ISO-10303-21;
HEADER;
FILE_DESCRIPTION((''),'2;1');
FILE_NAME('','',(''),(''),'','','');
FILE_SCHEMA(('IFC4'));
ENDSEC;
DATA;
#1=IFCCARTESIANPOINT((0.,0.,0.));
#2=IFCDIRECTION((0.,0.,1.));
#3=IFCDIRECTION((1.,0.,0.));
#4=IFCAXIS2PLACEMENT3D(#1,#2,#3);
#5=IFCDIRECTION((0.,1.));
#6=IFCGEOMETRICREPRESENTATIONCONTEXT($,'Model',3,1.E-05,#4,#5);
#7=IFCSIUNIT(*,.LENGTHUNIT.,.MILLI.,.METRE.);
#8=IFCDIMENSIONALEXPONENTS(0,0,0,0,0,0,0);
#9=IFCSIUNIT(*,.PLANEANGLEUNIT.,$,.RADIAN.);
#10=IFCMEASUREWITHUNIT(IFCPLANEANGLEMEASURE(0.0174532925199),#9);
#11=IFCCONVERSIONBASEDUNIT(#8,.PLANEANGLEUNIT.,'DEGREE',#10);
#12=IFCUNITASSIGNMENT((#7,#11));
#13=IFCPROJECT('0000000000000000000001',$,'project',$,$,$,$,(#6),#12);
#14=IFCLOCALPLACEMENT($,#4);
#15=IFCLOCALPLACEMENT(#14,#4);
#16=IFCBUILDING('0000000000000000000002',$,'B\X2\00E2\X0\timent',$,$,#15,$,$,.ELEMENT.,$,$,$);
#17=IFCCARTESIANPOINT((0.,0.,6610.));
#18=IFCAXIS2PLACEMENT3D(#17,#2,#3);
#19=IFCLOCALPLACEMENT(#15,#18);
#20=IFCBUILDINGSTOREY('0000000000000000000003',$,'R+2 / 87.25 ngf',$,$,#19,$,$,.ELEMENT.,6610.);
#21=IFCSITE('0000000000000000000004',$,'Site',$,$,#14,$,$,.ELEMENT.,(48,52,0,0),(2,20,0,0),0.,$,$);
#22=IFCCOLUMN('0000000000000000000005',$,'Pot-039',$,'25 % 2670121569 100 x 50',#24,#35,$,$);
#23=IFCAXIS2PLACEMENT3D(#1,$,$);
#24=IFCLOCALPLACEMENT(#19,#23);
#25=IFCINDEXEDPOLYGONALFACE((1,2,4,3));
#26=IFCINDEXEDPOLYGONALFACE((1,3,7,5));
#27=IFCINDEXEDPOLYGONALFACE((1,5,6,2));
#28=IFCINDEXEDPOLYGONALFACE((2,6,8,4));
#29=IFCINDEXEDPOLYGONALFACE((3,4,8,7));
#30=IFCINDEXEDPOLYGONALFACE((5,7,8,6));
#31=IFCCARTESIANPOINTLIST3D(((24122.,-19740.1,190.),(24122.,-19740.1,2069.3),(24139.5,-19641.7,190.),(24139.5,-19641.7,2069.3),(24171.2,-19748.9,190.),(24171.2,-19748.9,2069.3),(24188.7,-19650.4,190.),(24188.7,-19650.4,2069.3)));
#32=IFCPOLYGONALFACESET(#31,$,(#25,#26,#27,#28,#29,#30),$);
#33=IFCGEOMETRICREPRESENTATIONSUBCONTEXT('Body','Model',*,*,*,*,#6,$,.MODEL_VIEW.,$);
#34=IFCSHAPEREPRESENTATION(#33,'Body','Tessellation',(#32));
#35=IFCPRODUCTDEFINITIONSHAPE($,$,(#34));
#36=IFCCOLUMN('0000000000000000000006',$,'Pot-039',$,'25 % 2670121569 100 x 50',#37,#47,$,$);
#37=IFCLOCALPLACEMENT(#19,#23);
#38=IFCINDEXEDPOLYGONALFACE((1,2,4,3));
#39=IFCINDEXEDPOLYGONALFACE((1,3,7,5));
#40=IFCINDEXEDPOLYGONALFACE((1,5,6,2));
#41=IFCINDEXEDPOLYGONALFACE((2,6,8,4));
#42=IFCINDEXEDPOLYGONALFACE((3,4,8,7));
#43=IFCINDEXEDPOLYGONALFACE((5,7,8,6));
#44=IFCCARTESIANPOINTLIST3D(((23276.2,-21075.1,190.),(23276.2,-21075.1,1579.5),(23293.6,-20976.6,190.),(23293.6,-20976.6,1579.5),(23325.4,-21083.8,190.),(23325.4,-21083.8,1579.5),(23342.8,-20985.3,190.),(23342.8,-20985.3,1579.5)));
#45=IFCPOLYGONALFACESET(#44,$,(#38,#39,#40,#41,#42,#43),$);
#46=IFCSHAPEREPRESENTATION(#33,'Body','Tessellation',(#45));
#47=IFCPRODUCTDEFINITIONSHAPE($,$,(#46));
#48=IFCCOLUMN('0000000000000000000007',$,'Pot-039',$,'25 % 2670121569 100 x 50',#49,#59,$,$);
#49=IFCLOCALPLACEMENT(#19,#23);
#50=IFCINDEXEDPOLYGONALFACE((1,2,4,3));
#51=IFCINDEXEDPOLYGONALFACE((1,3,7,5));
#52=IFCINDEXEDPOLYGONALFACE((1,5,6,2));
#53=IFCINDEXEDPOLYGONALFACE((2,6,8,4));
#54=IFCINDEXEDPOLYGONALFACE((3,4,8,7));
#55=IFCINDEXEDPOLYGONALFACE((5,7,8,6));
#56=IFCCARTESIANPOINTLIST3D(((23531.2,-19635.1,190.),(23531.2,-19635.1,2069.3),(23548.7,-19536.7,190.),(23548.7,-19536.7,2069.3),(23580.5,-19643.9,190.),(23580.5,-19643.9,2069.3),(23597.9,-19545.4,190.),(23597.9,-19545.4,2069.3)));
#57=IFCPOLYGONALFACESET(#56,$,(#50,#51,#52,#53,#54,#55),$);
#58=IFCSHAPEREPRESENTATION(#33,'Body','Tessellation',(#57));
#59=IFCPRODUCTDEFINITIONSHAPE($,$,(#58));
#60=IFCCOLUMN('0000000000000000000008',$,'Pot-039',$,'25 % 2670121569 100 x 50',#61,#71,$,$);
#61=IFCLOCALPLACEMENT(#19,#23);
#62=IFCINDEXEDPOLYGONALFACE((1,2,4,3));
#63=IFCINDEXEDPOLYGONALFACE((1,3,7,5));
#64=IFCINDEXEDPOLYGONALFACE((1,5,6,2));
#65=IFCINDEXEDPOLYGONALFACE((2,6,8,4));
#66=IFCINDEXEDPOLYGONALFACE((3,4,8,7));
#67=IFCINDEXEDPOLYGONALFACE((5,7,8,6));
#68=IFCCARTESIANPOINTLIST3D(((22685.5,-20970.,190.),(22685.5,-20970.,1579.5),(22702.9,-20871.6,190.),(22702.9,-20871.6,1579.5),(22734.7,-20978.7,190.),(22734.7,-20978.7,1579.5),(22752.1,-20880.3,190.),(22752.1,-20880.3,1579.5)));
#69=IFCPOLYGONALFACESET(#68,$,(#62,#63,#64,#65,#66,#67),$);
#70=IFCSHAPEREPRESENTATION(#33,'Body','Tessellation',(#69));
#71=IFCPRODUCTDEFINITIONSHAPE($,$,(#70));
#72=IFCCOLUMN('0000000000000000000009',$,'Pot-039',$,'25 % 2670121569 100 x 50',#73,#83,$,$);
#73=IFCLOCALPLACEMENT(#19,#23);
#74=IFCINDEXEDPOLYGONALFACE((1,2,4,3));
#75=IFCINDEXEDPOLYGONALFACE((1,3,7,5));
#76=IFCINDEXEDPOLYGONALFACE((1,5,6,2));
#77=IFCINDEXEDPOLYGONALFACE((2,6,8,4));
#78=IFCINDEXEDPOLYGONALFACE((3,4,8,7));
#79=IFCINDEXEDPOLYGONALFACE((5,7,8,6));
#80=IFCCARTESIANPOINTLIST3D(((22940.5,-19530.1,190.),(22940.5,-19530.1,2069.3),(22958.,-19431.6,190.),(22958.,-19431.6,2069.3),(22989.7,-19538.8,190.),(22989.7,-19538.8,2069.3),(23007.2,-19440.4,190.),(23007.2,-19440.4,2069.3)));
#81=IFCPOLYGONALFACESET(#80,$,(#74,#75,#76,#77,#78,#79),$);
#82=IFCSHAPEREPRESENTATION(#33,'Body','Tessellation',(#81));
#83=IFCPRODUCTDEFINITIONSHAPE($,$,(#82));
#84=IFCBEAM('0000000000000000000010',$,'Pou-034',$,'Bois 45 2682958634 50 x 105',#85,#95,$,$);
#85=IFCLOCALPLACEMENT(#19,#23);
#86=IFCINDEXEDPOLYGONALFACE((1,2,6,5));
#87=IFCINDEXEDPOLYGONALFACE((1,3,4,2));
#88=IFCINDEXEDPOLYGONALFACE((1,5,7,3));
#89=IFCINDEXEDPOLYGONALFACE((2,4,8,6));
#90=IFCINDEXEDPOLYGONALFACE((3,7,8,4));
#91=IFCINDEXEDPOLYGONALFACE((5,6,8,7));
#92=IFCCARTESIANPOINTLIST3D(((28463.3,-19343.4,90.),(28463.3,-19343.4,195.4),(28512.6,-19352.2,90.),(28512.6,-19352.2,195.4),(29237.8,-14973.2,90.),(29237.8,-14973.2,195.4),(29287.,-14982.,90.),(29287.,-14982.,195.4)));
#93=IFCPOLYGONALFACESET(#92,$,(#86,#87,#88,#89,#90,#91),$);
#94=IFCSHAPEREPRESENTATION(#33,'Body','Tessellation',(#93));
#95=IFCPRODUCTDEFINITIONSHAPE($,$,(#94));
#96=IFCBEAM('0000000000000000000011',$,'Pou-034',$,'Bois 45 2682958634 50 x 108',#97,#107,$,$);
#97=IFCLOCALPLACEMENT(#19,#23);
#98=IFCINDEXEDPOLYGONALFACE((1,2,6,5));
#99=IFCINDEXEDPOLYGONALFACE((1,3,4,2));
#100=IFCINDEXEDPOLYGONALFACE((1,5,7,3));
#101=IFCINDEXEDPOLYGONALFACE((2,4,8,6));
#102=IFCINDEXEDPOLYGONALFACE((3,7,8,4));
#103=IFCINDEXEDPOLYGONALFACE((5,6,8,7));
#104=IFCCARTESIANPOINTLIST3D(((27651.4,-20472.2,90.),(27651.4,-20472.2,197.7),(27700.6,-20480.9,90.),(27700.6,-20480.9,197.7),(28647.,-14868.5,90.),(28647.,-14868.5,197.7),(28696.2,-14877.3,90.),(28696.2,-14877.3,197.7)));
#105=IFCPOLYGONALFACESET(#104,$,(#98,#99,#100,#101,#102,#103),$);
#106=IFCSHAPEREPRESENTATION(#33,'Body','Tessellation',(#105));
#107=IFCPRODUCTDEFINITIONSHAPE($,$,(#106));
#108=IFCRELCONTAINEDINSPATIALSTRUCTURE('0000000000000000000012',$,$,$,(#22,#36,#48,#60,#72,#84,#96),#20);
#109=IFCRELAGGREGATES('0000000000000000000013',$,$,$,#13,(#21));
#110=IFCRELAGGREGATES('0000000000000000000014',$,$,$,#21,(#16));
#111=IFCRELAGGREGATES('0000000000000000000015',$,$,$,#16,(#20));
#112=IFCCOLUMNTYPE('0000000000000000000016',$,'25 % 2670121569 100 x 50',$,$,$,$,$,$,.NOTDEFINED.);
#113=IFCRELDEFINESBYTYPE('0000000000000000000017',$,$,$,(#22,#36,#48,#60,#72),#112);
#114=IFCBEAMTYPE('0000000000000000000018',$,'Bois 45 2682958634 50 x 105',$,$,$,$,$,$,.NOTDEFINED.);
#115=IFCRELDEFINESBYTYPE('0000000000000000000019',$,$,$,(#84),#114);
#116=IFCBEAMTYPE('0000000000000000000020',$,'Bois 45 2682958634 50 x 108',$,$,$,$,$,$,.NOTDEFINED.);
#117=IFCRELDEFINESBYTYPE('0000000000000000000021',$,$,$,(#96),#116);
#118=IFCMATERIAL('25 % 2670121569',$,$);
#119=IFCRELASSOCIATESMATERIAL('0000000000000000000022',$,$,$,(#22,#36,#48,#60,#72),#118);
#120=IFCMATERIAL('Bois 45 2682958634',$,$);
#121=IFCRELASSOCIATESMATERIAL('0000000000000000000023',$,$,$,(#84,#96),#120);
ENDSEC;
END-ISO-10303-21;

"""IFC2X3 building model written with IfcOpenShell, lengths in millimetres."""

from ifc_helpers import new_model, entity, si_unit, converted_unit, direction, frame, frame_2d, origin_with_axes, origin_2d_with_axis, place, context, subcontext, project, spatial, rectangle, extrude, material, type_object, element, save


model = new_model("IFC2X3")

# Units and contexts
model_context = context("Model", 3, precision=1e-05, world=origin_with_axes(), true_north=direction((0.0, 1.0)))
body_context = subcontext(model_context, "Body", "Model", "MODEL_VIEW")
ifc_project = project(units=[si_unit("LENGTHUNIT", "METRE", prefix="MILLI"), converted_unit("PLANEANGLEUNIT", "DEGREE", entity("IfcPlaneAngleMeasure", 0.0174532925199), si_unit("PLANEANGLEUNIT", "RADIAN"), dimensions=[0, 0, 0, 0, 0, 0, 0])], contexts=[model_context])

# Site, building, storey
site_placement = place(None, origin_with_axes())
site = spatial("IfcSite", under=ifc_project, at=site_placement, Name="Site", CompositionType="ELEMENT", RefLatitude=(48, 52, 0, 0), RefLongitude=(2, 20, 0, 0), RefElevation=0.0)
building_placement = place(site_placement, origin_with_axes())
building = spatial("IfcBuilding", under=site, at=building_placement, Name="Bâtiment", CompositionType="ELEMENT")
storey_placement = place(building_placement, frame((0.0, 0.0, 6610.0), z_axis=(0.0, 0.0, 1.0), x_axis=(1.0, 0.0, 0.0)))
storey = spatial("IfcBuildingStorey", under=building, at=storey_placement, Name="R+2 / 87.25 ngf", CompositionType="ELEMENT", Elevation=6610.0)

# Columns
ifc_material_1 = material(Name="25 % 2670121569")
column_type = type_object("IfcColumnType", Name="25 % 2670121569 100 x 50", PredefinedType="NOTDEFINED")
column_1_placement = place(storey_placement, frame((24155.3, -19695.3, 190.0), z_axis=(0.0, 0.0, 1.0), x_axis=(0.17478, 0.984607, 0.0)))
element("IfcColumn", 1, at=column_1_placement, inside=storey, type_object=column_type, material=ifc_material_1, Name="Pot-039", ObjectType="25 % 2670121569 100 x 50", context=body_context, shape_type="SweptSolid", body=[
    extrude(rectangle(XDim=100.0, YDim=50.0, at=origin_2d_with_axis()), origin_with_axes(), (0.0, 0.0, 1.0), 1879.3),
])
column_2_placement = place(storey_placement, frame((23309.5, -21030.2, 190.0), z_axis=(0.0, 0.0, 1.0), x_axis=(0.17408, 0.984731, 0.0)))
element("IfcColumn", 2, at=column_2_placement, inside=storey, type_object=column_type, material=ifc_material_1, Name="Pot-039", ObjectType="25 % 2670121569 100 x 50", context=body_context, shape_type="SweptSolid", body=[
    extrude(rectangle(XDim=100.0, YDim=50.0, at=origin_2d_with_axis()), origin_with_axes(), (0.0, 0.0, 1.0), 1389.5),
])
column_3_placement = place(storey_placement, frame((23564.6, -19590.3, 190.0), z_axis=(0.0, 0.0, 1.0), x_axis=(0.17478, 0.984607, 0.0)))
element("IfcColumn", 3, at=column_3_placement, inside=storey, type_object=column_type, material=ifc_material_1, Name="Pot-039", ObjectType="25 % 2670121569 100 x 50", context=body_context, shape_type="SweptSolid", body=[
    extrude(rectangle(XDim=100.0, YDim=50.0, at=origin_2d_with_axis()), origin_with_axes(), (0.0, 0.0, 1.0), 1879.3),
])
column_4_placement = place(storey_placement, frame((22718.8, -20925.1, 190.0), z_axis=(0.0, 0.0, 1.0), x_axis=(0.17408, 0.984731, 0.0)))
element("IfcColumn", 4, at=column_4_placement, inside=storey, type_object=column_type, material=ifc_material_1, Name="Pot-039", ObjectType="25 % 2670121569 100 x 50", context=body_context, shape_type="SweptSolid", body=[
    extrude(rectangle(XDim=100.0, YDim=50.0, at=origin_2d_with_axis()), origin_with_axes(), (0.0, 0.0, 1.0), 1389.5),
])
column_5_placement = place(storey_placement, frame((22973.9, -19485.2, 190.0), z_axis=(0.0, 0.0, 1.0), x_axis=(0.17478, 0.984607, 0.0)))
element("IfcColumn", 5, at=column_5_placement, inside=storey, type_object=column_type, material=ifc_material_1, Name="Pot-039", ObjectType="25 % 2670121569 100 x 50", context=body_context, shape_type="SweptSolid", body=[
    extrude(rectangle(XDim=100.0, YDim=50.0, at=origin_2d_with_axis()), origin_with_axes(), (0.0, 0.0, 1.0), 1879.3),
])

# Beams
ifc_material_2 = material(Name="Bois 45 2682958634")
beam_type_1 = type_object("IfcBeamType", Name="Bois 45 2682958634 50 x 105", PredefinedType="NOTDEFINED")
beam_1_placement = place(storey_placement, frame((28488.0, -19347.8, 195.4), z_axis=(0.0, 0.0, 1.0), x_axis=(0.984659, -0.174492, 0.0)))
element("IfcBeam", 6, at=beam_1_placement, inside=storey, type_object=beam_type_1, material=ifc_material_2, Name="Pou-034", ObjectType="Bois 45 2682958634 50 x 105", context=body_context, shape_type="SweptSolid", body=[
    extrude(rectangle(XDim=105.4, YDim=50.0, at=frame_2d((-52.7, 0.0), x_axis=(1.0, 0.0))), frame((0.0, 0.0, 0.0), z_axis=(0.0, 1.0, 0.0), x_axis=(0.0, 0.0, 1.0)), (0.0, 0.0, 1.0), 4438.3),
])
beam_type_2 = type_object("IfcBeamType", Name="Bois 45 2682958634 50 x 108", PredefinedType="NOTDEFINED")
beam_2_placement = place(storey_placement, frame((27676.0, -20476.6, 197.7), z_axis=(0.0, 0.0, 1.0), x_axis=(0.984579, -0.174938, 0.0)))
element("IfcBeam", 7, at=beam_2_placement, inside=storey, type_object=beam_type_2, material=ifc_material_2, Name="Pou-034", ObjectType="Bois 45 2682958634 50 x 108", context=body_context, shape_type="SweptSolid", body=[
    extrude(rectangle(XDim=107.7, YDim=50.0, at=frame_2d((-53.9, 0.0), x_axis=(1.0, 0.0))), frame((0.0, 0.0, 0.0), z_axis=(0.0, 1.0, 0.0), x_axis=(0.0, 0.0, 1.0)), (0.0, 0.0, 1.0), 5691.4),
])

save(model, "model.ifc")
